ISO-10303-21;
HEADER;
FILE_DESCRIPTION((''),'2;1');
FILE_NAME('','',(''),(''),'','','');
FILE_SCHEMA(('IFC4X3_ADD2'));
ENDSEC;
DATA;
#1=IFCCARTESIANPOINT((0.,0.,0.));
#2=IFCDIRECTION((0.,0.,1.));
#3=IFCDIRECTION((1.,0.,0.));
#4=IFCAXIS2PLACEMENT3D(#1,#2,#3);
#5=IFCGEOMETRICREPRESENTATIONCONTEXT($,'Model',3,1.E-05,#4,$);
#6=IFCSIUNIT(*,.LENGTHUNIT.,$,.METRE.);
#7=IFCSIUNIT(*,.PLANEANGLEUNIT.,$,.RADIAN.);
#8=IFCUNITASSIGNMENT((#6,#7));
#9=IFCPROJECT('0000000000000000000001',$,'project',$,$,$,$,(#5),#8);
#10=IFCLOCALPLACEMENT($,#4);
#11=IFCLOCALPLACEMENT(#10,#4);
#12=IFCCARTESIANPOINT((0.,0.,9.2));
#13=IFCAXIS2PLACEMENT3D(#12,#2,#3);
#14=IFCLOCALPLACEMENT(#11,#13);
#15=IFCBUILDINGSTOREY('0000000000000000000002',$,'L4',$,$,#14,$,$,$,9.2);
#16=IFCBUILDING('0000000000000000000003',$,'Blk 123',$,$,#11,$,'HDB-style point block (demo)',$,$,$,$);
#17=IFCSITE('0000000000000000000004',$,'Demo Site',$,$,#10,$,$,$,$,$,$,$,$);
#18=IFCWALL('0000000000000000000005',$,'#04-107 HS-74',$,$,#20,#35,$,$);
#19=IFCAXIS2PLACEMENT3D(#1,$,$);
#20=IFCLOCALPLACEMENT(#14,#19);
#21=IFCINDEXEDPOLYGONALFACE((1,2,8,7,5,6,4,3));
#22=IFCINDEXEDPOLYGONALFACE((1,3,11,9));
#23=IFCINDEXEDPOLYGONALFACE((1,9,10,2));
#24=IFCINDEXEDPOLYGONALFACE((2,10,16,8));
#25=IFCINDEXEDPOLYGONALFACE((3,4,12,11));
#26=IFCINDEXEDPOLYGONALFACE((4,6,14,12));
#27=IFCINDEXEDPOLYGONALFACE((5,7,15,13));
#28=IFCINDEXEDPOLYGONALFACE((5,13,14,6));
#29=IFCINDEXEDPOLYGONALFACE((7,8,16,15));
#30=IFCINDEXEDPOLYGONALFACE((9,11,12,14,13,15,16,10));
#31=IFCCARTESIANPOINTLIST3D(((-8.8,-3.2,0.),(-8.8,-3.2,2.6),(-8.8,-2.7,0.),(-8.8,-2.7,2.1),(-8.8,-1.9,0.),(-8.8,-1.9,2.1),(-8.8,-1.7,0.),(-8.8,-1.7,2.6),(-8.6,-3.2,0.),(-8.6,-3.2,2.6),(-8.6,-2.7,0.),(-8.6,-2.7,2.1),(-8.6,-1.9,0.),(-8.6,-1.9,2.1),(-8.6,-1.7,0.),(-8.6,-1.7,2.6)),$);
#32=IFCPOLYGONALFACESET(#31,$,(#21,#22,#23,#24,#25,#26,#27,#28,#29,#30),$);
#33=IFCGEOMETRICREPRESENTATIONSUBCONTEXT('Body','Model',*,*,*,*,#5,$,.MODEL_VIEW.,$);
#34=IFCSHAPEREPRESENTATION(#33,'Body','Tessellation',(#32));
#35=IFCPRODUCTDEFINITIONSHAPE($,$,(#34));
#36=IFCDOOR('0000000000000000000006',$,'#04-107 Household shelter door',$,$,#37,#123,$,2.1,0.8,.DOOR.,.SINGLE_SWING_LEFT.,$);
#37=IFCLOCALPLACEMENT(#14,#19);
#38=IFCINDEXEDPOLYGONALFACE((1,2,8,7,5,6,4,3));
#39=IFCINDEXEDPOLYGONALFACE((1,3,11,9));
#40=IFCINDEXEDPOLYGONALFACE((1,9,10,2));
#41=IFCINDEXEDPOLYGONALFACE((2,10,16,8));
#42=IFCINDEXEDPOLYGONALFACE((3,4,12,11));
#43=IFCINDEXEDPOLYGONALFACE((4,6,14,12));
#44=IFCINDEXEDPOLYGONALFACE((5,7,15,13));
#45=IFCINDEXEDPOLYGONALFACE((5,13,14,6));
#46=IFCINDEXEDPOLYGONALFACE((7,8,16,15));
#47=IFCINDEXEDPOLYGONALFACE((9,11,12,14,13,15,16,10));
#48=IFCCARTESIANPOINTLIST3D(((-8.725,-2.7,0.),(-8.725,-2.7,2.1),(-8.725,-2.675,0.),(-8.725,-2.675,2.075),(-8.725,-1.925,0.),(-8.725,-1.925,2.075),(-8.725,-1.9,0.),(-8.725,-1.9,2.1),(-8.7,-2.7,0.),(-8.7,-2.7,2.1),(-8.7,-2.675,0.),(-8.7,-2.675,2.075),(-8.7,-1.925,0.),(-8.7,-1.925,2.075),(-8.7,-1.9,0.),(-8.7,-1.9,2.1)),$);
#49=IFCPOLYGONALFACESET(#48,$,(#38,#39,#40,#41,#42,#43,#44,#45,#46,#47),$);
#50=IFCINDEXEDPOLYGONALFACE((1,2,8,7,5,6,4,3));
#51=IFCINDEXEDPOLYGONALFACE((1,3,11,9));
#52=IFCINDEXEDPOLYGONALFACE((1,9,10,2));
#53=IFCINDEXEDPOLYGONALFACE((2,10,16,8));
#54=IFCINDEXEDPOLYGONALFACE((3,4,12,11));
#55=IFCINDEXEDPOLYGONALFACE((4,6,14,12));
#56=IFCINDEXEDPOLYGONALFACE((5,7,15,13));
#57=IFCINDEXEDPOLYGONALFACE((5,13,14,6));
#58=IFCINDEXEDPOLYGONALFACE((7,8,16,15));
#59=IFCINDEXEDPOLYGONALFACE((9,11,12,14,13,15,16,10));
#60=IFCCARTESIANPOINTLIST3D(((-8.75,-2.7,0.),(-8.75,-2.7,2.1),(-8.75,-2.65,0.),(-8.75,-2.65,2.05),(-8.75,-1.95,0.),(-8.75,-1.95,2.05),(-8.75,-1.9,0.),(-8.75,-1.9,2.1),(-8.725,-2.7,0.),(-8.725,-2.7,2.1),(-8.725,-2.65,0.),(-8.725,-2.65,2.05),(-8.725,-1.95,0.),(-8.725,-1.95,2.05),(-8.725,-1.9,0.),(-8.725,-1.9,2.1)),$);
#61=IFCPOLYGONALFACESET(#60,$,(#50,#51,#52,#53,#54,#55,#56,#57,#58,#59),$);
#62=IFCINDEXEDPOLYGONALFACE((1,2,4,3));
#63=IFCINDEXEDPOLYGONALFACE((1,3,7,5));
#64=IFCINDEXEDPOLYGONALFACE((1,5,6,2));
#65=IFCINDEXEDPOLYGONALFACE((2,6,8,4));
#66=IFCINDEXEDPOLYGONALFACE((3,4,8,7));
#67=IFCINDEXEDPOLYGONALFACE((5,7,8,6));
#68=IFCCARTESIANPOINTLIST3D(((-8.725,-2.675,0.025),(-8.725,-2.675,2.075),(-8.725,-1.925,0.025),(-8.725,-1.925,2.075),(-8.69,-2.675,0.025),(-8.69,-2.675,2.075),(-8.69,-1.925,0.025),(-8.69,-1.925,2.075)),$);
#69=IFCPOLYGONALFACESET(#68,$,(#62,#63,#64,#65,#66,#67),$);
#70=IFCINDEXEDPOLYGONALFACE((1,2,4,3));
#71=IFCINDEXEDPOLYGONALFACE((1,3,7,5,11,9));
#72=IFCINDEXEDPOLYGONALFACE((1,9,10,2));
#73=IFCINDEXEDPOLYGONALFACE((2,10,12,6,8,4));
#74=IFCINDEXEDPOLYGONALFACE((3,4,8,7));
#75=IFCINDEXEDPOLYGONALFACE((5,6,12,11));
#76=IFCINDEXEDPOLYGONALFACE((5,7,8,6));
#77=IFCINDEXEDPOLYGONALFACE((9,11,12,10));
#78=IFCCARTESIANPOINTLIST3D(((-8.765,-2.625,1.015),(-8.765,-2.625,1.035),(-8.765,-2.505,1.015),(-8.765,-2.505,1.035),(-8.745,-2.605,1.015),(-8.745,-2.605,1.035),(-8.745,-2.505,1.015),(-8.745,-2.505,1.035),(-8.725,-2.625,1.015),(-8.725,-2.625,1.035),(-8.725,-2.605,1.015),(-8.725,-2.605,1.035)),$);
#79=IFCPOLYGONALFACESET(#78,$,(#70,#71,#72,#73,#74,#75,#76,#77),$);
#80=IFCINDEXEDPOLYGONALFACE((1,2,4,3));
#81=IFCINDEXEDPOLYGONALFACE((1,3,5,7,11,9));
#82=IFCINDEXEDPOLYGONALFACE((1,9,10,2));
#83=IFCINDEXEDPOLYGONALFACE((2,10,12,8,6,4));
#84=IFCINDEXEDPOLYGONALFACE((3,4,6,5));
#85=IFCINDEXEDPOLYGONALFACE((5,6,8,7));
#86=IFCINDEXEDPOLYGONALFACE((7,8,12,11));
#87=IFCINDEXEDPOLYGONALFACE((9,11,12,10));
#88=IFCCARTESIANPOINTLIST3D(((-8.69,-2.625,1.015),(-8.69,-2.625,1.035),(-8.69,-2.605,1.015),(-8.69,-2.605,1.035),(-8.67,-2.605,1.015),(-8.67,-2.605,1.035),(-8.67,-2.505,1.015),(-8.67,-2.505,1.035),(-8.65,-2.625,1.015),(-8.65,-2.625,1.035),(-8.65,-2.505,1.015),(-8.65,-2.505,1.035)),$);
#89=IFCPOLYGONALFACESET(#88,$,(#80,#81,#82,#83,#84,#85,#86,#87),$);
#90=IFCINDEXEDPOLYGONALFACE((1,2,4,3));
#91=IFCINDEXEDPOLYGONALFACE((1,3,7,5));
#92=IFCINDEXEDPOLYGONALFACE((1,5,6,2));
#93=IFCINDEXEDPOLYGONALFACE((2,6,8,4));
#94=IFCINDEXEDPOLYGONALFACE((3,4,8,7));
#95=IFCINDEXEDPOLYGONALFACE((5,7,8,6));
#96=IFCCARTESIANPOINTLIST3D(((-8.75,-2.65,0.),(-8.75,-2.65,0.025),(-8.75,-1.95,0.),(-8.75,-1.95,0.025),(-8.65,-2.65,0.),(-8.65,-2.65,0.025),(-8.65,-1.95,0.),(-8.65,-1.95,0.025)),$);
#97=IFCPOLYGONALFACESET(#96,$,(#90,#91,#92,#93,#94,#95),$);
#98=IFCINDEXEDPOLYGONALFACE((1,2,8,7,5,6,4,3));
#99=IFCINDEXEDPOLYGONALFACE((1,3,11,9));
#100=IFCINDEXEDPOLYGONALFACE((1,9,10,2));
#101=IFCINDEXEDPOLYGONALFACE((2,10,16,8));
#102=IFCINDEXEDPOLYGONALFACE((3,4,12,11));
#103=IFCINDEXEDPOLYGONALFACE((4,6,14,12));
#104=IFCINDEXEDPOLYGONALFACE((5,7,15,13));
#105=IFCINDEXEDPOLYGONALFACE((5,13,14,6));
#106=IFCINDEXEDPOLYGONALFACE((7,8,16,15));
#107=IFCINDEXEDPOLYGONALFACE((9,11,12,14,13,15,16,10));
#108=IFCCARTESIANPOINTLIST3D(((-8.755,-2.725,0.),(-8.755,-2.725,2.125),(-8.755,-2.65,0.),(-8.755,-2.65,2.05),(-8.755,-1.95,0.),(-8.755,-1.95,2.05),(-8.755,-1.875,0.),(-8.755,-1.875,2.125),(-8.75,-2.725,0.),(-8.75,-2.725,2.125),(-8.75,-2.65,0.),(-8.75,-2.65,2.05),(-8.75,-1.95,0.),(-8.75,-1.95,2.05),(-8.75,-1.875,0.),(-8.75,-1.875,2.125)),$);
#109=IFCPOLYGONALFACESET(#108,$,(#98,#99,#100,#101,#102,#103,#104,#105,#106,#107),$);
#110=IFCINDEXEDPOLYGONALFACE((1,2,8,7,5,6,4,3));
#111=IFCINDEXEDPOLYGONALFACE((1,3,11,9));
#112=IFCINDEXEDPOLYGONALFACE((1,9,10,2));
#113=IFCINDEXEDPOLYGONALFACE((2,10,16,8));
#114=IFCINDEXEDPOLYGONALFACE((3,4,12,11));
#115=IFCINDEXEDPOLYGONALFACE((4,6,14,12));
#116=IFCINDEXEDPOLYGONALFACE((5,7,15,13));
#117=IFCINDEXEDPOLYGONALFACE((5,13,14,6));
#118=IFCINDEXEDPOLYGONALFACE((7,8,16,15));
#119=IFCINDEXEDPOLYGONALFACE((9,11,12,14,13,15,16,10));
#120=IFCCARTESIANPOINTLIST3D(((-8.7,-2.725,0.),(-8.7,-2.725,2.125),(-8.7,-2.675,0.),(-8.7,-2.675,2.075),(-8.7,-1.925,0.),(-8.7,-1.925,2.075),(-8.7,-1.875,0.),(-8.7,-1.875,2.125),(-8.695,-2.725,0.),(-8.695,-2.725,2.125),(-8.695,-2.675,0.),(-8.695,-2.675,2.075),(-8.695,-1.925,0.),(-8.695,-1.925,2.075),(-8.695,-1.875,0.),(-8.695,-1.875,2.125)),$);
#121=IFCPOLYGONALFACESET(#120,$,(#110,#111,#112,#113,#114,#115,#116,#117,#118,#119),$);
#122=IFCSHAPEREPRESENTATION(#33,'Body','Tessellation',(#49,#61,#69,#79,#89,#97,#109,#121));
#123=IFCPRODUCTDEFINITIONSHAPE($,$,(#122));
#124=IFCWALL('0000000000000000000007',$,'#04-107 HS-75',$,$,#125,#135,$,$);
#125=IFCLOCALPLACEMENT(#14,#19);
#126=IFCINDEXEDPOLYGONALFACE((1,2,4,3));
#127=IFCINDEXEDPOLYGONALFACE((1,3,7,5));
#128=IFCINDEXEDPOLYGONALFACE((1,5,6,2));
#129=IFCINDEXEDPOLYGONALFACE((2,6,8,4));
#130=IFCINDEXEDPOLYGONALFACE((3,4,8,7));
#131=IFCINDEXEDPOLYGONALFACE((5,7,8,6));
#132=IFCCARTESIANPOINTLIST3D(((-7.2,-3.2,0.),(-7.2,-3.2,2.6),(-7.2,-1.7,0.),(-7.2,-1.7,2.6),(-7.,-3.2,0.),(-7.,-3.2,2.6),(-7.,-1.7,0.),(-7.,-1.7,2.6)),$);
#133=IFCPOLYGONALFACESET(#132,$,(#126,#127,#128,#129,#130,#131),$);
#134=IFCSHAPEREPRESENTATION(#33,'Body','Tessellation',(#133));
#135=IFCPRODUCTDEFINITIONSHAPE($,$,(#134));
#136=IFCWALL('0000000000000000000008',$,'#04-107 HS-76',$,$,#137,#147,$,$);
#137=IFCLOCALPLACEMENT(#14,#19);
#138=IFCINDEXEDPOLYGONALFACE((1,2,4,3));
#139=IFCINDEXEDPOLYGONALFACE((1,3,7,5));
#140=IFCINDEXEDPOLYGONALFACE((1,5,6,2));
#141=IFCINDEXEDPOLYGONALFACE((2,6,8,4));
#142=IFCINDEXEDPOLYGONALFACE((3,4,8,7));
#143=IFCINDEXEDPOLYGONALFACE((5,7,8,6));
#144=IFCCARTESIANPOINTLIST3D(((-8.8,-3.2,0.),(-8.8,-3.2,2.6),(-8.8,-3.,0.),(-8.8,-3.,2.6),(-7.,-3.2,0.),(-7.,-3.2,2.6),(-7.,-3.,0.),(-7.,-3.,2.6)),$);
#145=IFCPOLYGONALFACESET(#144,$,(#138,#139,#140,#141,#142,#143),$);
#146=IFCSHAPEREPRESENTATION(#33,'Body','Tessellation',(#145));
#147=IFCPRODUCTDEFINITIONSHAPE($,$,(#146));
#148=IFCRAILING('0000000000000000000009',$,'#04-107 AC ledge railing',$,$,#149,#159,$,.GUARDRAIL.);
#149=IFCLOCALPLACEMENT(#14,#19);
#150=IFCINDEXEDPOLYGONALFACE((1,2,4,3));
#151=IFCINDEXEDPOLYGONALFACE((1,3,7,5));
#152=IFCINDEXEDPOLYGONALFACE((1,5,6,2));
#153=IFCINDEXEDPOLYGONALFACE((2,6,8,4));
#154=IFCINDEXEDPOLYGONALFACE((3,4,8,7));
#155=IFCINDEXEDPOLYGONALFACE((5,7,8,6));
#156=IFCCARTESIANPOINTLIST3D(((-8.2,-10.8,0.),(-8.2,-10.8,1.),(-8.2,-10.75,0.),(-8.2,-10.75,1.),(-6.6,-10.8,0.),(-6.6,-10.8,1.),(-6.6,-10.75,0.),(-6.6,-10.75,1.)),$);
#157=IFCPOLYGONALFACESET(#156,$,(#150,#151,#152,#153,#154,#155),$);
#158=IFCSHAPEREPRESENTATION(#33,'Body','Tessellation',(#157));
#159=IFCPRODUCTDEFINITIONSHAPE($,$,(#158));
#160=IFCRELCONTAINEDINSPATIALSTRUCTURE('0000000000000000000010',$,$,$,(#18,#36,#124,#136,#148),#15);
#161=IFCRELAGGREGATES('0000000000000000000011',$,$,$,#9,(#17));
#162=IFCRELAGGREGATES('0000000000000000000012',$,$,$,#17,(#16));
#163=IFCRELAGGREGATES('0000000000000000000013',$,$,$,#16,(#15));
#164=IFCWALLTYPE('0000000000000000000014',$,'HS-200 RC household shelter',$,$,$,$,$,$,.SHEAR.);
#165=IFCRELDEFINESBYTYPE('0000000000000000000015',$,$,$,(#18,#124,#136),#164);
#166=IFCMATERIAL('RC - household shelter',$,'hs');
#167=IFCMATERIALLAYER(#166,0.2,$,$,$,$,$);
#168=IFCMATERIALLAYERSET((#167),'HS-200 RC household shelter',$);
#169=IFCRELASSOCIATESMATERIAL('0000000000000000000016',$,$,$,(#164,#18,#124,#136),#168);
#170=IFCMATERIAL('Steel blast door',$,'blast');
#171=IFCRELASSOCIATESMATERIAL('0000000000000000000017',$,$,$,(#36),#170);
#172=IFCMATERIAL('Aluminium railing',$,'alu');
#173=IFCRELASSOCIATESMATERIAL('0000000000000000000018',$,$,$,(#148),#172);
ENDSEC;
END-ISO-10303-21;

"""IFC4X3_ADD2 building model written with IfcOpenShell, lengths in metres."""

from ifc_helpers import new_model, si_unit, frame, origin, origin_with_axes, place, context, subcontext, project, spatial, polyline, line, indexed_curve, outline, extrude, material, layer, layer_set, layer_usage, type_object, element, fill, save


model = new_model("IFC4X3_ADD2")

# Units and contexts
model_context = context("Model", 3, precision=1e-05, world=origin_with_axes())
body_context = subcontext(model_context, "Body", "Model", "MODEL_VIEW")
ifc_project = project(units=[si_unit("LENGTHUNIT", "METRE"), si_unit("PLANEANGLEUNIT", "RADIAN")], contexts=[model_context])

# Site, building, storey
site_placement = place(None, origin_with_axes())
site = spatial("IfcSite", under=ifc_project, at=site_placement, Name="Demo Site")
building_placement = place(site_placement, origin_with_axes())
building = spatial("IfcBuilding", under=site, at=building_placement, Name="Blk 123", LongName="HDB-style point block (demo)")
storey_placement = place(building_placement, frame((0.0, 0.0, 9.2), z_axis=(0.0, 0.0, 1.0), x_axis=(1.0, 0.0, 0.0)))
storey = spatial("IfcBuildingStorey", under=building, at=storey_placement, Name="L4", Elevation=9.2)

# Wall, opening, door
ifc_material_1 = material(Name="RC - household shelter", Category="hs")
ifc_layer_1 = layer(ifc_material_1, 0.2)
ifc_layer_set_1 = layer_set([ifc_layer_1], Name="HS-200 RC household shelter")
ifc_layer_usage_1 = layer_usage(ifc_layer_set_1, "AXIS2", "POSITIVE", -0.1)
wall_type_1 = type_object("IfcWallType", Name="HS-200 RC household shelter", PredefinedType="SHEAR", material=ifc_layer_set_1)
wall_1_placement = place(storey_placement, frame((-8.7, -1.7, 0.0), z_axis=(0.0, 0.0, 1.0), x_axis=(0.0, -1.0, 0.0)))
wall_1 = element("IfcWall", 1, at=wall_1_placement, inside=storey, type_object=wall_type_1, material=ifc_layer_usage_1, Name="#04-107 HS-74", context=body_context, shape_type="SweptSolid", body=[
    extrude(outline(indexed_curve([(0.0, 0.0), (0.0, 0.2), (1.5, 0.2), (1.5, 0.0), (0.0, 0.0)], self_intersect=False)), frame((0.0, -0.1, 0.0), z_axis=(0.0, 0.0, 1.0), x_axis=(1.0, 0.0, 0.0)), (0.0, 0.0, 1.0), 2.6),
])
opening_1_placement = place(wall_1_placement, frame((0.2, -0.2, 0.0), z_axis=(0.0, 0.0, 1.0), x_axis=(1.0, 0.0, 0.0)))
opening_1 = element("IfcOpeningElement", 2, at=opening_1_placement, cuts=wall_1, context=body_context, shape_type="SweptSolid", body=[
    extrude(outline(indexed_curve([(0.0, 0.0), (0.0, 0.4), (0.8, 0.4), (0.8, 0.0), (0.0, 0.0)], self_intersect=False)), origin_with_axes(), (0.0, 0.0, 1.0), 2.1),
])
ifc_material_2 = material(Name="Steel blast door", Category="blast")
door_1_placement = place(opening_1_placement, frame((0.0, 0.15, 0.0), z_axis=(0.0, 0.0, 1.0), x_axis=(1.0, 0.0, 0.0)))
door_1 = element("IfcDoor", 3, at=door_1_placement, inside=storey, material=ifc_material_2, Name="#04-107 Household shelter door", OperationType="SINGLE_SWING_LEFT", OverallHeight=2.1, OverallWidth=0.8, PredefinedType="DOOR", context=body_context, shape_type="SweptSolid", body=[
    extrude(outline(indexed_curve([(0.0, 0.0), (0.0, 2.1), (0.8, 2.1), (0.8, 0.0), (0.775, 0.0), (0.775, 2.075), (0.025, 2.075), (0.025, 0.0)], segments=[line(1, 2, 3, 4, 5, 6, 7, 8, 1)])), frame((0.0, 0.025, 0.0), z_axis=(0.0, -1.0, 0.0), x_axis=(1.0, 0.0, 0.0)), (0.0, 0.0, -1.0), 0.025),
    extrude(outline(indexed_curve([(0.0, 0.0), (0.0, 2.1), (0.8, 2.1), (0.8, 0.0), (0.75, 0.0), (0.75, 2.05), (0.05, 2.05), (0.05, 0.0)], segments=[line(1, 2, 3, 4, 5, 6, 7, 8, 1)])), frame((0.0, 0.0, 0.0), z_axis=(0.0, -1.0, 0.0), x_axis=(1.0, 0.0, 0.0)), (0.0, 0.0, -1.0), 0.025),
    extrude(outline(indexed_curve([(0.0, 0.0), (0.75, 0.0), (0.75, 0.035), (0.0, 0.035)], segments=[line(1, 2, 3, 4, 1)])), frame((0.025, 0.025, 0.025), z_axis=(0.0, 0.0, 1.0), x_axis=(1.0, 0.0, 0.0)), (0.0, 0.0, 1.0), 2.05),
    extrude(outline(indexed_curve([(0.0, 0.0), (0.0, -0.04), (-0.12, -0.04), (-0.12, -0.02), (-0.02, -0.02), (-0.02, 0.0)], segments=[line(1, 2, 3, 4, 5, 6, 1)])), frame((0.725, 0.025, 1.015), z_axis=(0.0, 0.0, 1.0), x_axis=(1.0, 0.0, 0.0)), (0.0, 0.0, 1.0), 0.02),
    extrude(outline(indexed_curve([(0.0, 0.0), (0.0, 0.04), (-0.12, 0.04), (-0.12, 0.02), (-0.02, 0.02), (-0.02, 0.0)], segments=[line(1, 2, 3, 4, 5, 6, 1)])), frame((0.725, 0.06, 1.015), z_axis=(0.0, 0.0, 1.0), x_axis=(1.0, 0.0, 0.0)), (0.0, 0.0, 1.0), 0.02),
    extrude(outline(indexed_curve([(0.0, 0.0), (0.7, 0.0), (0.7, 0.1), (0.0, 0.1)], segments=[line(1, 2, 3, 4, 1)])), frame((0.05, 0.0, 0.0), z_axis=(0.0, 0.0, 1.0), x_axis=(1.0, 0.0, 0.0)), (0.0, 0.0, 1.0), 0.025),
    extrude(outline(indexed_curve([(0.0, 0.0), (0.0, 2.125), (0.85, 2.125), (0.85, 0.0), (0.775, 0.0), (0.775, 2.05), (0.075, 2.05), (0.075, 0.0)], segments=[line(1, 2, 3, 4, 5, 6, 7, 8, 1)])), frame((-0.025, -0.005, 0.0), z_axis=(0.0, -1.0, 0.0), x_axis=(1.0, 0.0, 0.0)), (0.0, 0.0, -1.0), 0.005),
    extrude(outline(indexed_curve([(0.0, 0.0), (0.0, 2.125), (0.85, 2.125), (0.85, 0.0), (0.8, 0.0), (0.8, 2.075), (0.05, 2.075), (0.05, 0.0)], segments=[line(1, 2, 3, 4, 5, 6, 7, 8, 1)])), frame((-0.025, 0.05, 0.0), z_axis=(0.0, -1.0, 0.0), x_axis=(1.0, 0.0, 0.0)), (0.0, 0.0, -1.0), 0.005),
])
fill(opening_1, door_1)

# Walls
wall_2_placement = place(storey_placement, frame((-7.1, -1.7, 0.0), z_axis=(0.0, 0.0, 1.0), x_axis=(0.0, -1.0, 0.0)))
element("IfcWall", 4, at=wall_2_placement, inside=storey, type_object=wall_type_1, material=ifc_layer_usage_1, Name="#04-107 HS-75", context=body_context, shape_type="SweptSolid", body=[
    extrude(outline(indexed_curve([(0.0, 0.0), (0.0, 0.2), (1.5, 0.2), (1.5, 0.0), (0.0, 0.0)], self_intersect=False)), frame((0.0, -0.1, 0.0), z_axis=(0.0, 0.0, 1.0), x_axis=(1.0, 0.0, 0.0)), (0.0, 0.0, 1.0), 2.6),
])
wall_3_placement = place(storey_placement, frame((-7.0, -3.1, 0.0), z_axis=(0.0, 0.0, 1.0), x_axis=(-1.0, 0.0, 0.0)))
element("IfcWall", 5, at=wall_3_placement, inside=storey, type_object=wall_type_1, material=ifc_layer_usage_1, Name="#04-107 HS-76", context=body_context, shape_type="SweptSolid", body=[
    extrude(outline(indexed_curve([(0.0, 0.0), (0.0, 0.2), (1.8, 0.2), (1.8, 0.0), (0.0, 0.0)], self_intersect=False)), frame((0.0, -0.1, 0.0), z_axis=(0.0, 0.0, 1.0), x_axis=(1.0, 0.0, 0.0)), (0.0, 0.0, 1.0), 2.6),
])

# Railing
ifc_material_3 = material(Name="Aluminium railing", Category="alu")
railing_placement = place(storey_placement, frame((-7.4, -10.775, 0.0), z_axis=(0.0, 0.0, 1.0), x_axis=(1.0, 0.0, 0.0)))
element("IfcRailing", 6, at=railing_placement, inside=storey, material=ifc_material_3, Name="#04-107 AC ledge railing", PredefinedType="GUARDRAIL", context=body_context, shape_type="SweptSolid", body=[
    extrude(outline(polyline([(-0.8, 0.025), (-0.8, -0.025), (0.8, -0.025), (0.8, 0.025), (-0.8, 0.025)])), origin(), (0.0, 0.0, 1.0), 1.0),
])

save(model, "model.ifc")
